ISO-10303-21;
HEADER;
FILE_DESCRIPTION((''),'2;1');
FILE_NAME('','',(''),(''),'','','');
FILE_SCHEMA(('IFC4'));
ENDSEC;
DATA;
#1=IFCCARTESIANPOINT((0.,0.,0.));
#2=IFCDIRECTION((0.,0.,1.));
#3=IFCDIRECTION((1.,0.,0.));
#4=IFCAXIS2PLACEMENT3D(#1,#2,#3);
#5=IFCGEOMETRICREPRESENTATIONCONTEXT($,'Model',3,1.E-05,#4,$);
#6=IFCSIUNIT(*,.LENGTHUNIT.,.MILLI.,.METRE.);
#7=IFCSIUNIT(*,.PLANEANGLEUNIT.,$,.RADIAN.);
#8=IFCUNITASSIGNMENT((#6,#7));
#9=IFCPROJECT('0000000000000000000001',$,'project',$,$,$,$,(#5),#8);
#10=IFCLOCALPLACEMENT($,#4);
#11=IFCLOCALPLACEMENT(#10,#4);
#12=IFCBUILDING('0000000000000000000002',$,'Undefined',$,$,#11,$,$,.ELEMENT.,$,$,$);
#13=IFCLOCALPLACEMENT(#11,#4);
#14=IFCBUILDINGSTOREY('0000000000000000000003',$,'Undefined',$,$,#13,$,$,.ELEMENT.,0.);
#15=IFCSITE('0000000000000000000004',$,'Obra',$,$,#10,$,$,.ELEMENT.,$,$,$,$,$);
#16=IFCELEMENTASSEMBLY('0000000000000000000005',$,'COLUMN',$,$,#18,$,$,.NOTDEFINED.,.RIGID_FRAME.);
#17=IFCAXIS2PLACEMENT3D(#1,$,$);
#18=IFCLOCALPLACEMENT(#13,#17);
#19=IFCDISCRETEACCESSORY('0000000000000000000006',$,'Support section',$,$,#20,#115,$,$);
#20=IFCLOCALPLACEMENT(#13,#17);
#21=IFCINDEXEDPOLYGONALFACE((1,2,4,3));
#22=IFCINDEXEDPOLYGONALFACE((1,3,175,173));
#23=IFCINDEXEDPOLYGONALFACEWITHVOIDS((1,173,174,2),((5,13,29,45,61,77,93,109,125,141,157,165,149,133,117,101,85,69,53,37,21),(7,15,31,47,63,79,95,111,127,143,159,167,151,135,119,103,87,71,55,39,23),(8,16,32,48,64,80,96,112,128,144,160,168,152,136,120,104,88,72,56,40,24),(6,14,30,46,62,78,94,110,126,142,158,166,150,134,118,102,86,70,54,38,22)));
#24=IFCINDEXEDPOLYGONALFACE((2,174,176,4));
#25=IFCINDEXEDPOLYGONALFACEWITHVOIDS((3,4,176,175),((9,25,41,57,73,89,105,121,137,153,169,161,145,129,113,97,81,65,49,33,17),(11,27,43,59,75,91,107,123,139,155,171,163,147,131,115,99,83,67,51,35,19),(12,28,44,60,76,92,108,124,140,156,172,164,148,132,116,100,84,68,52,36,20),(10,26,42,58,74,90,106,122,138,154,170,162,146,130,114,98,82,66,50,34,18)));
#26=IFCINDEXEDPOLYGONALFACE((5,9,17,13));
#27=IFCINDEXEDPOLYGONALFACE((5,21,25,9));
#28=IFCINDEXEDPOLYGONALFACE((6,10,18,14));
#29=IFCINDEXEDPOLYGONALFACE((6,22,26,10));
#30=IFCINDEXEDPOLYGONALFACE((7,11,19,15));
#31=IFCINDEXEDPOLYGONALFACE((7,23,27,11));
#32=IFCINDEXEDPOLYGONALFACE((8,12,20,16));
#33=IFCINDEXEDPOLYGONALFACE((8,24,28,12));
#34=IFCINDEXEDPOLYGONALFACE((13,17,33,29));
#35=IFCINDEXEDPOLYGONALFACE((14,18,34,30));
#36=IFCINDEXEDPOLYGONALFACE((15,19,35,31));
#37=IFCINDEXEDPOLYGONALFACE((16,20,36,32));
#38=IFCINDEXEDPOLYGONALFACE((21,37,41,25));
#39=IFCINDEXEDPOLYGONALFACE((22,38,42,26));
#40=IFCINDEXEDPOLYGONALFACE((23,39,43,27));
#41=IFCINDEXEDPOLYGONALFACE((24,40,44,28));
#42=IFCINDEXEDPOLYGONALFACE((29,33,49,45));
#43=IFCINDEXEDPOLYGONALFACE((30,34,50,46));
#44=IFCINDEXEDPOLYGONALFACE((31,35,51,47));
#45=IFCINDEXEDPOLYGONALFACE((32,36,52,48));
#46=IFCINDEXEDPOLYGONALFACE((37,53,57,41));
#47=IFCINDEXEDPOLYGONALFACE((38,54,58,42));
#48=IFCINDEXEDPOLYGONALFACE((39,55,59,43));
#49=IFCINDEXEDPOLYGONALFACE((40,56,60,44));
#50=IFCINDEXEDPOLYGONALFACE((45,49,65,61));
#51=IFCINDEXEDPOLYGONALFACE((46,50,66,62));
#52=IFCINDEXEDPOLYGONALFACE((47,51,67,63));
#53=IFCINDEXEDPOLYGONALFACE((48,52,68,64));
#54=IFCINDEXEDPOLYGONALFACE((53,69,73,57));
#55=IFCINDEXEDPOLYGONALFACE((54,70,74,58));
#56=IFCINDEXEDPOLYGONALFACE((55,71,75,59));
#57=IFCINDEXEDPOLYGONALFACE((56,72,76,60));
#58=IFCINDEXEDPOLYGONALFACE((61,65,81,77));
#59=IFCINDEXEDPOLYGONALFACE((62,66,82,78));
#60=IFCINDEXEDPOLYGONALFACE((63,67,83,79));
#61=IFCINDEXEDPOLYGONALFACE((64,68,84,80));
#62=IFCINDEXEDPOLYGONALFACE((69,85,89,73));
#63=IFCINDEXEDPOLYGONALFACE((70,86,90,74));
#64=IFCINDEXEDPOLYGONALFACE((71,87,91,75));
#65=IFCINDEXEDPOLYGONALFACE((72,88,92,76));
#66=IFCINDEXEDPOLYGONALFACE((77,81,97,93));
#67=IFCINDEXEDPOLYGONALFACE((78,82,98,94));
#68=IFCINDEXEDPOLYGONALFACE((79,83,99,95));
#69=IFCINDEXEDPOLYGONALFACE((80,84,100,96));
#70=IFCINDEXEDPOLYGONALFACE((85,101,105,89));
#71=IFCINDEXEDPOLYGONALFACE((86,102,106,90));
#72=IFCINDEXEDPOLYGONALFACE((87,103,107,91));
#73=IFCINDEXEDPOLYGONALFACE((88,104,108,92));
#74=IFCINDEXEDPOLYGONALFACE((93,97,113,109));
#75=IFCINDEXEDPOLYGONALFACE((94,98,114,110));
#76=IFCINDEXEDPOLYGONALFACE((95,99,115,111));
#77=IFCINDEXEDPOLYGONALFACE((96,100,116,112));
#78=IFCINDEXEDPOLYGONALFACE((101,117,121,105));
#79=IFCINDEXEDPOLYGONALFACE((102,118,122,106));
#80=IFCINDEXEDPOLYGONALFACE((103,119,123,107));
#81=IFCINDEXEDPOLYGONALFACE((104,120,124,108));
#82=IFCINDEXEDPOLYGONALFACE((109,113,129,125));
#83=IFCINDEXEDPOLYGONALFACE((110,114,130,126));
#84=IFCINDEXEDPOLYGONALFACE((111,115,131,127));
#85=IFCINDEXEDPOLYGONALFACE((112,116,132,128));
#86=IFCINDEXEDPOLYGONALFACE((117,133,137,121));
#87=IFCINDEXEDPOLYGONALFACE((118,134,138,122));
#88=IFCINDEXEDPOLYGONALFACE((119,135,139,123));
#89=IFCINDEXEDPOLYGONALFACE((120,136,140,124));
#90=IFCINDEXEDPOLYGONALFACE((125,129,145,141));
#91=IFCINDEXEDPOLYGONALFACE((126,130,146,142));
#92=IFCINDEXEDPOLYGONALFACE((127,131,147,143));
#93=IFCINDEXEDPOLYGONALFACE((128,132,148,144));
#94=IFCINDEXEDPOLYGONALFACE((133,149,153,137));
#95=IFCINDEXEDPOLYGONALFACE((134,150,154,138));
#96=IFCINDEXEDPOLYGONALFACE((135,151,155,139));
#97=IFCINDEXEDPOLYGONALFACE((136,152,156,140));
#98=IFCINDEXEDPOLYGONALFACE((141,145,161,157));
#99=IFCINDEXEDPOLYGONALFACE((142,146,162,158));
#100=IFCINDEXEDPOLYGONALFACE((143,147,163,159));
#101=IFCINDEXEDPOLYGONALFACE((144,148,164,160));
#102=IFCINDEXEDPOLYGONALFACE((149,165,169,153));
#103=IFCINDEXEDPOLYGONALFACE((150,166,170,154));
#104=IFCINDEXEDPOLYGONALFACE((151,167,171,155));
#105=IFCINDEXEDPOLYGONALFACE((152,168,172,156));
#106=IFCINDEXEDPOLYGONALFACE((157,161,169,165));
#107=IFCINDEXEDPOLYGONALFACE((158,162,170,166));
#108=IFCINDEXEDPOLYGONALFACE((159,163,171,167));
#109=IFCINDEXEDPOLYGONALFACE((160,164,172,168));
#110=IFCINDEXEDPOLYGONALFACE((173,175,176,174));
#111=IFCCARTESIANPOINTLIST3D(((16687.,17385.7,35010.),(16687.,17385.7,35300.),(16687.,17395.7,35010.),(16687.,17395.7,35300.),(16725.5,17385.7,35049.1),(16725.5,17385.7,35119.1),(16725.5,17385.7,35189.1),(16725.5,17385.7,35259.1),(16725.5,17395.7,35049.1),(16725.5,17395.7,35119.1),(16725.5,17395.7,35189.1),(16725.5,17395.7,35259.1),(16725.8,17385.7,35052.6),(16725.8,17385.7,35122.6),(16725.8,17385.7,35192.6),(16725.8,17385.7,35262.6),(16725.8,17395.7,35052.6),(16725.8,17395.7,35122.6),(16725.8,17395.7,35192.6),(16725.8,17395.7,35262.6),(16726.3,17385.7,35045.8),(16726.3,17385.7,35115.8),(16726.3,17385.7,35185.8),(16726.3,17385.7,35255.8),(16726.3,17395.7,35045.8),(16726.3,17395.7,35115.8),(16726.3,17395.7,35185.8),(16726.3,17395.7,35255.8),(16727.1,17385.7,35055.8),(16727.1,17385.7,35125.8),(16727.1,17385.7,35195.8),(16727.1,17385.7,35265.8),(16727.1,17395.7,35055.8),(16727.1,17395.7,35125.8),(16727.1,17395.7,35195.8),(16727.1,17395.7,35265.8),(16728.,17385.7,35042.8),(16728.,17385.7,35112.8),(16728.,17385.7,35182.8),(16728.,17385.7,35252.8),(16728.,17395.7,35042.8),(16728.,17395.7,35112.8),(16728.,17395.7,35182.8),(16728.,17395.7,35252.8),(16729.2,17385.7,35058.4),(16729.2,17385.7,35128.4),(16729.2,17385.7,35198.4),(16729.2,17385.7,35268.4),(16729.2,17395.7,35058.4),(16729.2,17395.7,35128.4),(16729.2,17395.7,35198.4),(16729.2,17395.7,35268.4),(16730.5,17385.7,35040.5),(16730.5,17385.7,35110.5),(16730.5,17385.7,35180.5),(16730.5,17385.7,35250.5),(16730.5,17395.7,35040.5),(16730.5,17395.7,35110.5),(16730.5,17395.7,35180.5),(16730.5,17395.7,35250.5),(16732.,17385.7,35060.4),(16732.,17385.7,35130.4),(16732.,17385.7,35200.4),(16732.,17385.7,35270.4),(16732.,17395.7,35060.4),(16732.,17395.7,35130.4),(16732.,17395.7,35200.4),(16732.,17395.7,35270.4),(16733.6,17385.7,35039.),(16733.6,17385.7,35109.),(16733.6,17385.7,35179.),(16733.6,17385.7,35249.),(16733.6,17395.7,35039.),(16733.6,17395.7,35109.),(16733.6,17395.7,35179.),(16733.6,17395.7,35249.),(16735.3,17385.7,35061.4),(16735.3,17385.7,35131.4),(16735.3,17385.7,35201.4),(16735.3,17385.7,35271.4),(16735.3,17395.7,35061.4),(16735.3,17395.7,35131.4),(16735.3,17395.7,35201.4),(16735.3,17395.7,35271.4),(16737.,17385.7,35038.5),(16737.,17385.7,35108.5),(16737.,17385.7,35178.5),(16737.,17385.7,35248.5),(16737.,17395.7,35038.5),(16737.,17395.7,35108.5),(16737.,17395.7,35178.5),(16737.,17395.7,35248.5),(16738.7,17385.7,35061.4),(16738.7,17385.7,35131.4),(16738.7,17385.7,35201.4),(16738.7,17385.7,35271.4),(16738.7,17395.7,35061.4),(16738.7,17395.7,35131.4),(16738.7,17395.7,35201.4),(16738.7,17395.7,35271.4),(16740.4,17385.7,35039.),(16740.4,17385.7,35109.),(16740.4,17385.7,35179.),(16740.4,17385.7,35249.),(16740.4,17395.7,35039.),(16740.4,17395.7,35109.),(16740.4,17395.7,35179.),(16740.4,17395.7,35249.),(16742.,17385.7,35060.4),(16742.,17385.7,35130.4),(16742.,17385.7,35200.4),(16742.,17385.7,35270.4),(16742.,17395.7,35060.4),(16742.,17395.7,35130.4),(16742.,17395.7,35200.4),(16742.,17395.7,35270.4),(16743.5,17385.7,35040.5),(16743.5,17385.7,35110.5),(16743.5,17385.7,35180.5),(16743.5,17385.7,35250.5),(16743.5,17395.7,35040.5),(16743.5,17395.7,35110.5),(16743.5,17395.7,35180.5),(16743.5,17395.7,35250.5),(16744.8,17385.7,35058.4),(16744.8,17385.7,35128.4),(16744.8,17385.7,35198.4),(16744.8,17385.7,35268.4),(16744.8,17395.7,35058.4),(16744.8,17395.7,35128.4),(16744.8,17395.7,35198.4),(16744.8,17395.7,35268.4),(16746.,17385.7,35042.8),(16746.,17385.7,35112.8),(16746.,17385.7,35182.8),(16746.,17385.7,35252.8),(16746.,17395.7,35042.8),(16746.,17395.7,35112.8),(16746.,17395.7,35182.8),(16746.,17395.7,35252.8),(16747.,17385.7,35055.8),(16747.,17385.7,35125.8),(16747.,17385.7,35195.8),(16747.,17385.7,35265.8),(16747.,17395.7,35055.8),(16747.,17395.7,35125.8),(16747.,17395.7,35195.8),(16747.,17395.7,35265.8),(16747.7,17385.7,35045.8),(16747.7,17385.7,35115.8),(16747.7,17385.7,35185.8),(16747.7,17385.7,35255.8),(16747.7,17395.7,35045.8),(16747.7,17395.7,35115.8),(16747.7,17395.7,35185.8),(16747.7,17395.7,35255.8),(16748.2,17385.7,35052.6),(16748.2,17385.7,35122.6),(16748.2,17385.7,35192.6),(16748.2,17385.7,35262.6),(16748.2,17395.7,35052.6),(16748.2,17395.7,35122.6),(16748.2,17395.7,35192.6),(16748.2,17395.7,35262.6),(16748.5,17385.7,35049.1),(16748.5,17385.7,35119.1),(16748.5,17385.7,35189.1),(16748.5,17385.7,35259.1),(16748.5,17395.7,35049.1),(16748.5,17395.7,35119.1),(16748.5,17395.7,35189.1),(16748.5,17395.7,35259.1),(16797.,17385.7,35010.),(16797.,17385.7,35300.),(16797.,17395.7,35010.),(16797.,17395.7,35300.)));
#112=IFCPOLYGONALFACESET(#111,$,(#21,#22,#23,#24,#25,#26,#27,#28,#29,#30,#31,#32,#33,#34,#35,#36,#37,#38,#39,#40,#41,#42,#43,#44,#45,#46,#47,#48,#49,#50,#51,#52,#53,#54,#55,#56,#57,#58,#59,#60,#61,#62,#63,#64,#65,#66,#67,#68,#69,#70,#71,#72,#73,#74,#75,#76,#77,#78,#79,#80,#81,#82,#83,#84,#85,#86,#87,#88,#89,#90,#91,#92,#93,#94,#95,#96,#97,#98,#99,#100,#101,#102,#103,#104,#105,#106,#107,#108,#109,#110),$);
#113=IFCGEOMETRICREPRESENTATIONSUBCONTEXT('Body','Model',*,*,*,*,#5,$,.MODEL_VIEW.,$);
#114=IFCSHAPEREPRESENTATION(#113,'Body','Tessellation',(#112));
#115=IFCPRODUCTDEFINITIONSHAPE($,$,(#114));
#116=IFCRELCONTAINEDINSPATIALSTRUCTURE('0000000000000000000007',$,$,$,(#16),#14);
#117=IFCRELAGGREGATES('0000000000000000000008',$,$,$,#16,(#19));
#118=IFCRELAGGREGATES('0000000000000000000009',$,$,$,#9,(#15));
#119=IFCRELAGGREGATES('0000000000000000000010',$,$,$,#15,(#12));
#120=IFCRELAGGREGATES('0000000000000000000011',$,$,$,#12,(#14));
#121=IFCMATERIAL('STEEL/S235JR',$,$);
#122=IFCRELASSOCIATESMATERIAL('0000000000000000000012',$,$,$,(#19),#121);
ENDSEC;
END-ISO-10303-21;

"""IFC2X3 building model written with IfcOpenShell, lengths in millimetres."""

from ifc_helpers import new_model, si_unit, frame, origin_with_axes, origin_2d_with_axis, place, context, subcontext, project, spatial, rectangle, circle, extrude, source, transform, mapped, material, element, aggregate, save


model = new_model("IFC2X3")

# Units and contexts
model_context = context("Model", 3, precision=1e-05, world=origin_with_axes())
body_context = subcontext(model_context, "Body", "Model", "MODEL_VIEW")
ifc_project = project(units=[si_unit("LENGTHUNIT", "METRE", prefix="MILLI"), si_unit("PLANEANGLEUNIT", "RADIAN")], contexts=[model_context])

# Site, building, storey
site_placement = place(None, origin_with_axes())
site = spatial("IfcSite", under=ifc_project, at=site_placement, Name="Obra", CompositionType="ELEMENT")
building_placement = place(site_placement, origin_with_axes())
building = spatial("IfcBuilding", under=site, at=building_placement, Name="Undefined", CompositionType="ELEMENT")
storey_placement = place(building_placement, origin_with_axes())
storey = spatial("IfcBuildingStorey", under=building, at=storey_placement, Name="Undefined", CompositionType="ELEMENT", Elevation=0.0)

# Shared definitions
ifc_material_1 = material(Name="STEEL/S235JR")

# Element assembly, discrete accessory, opening
assembly_1_placement = place(storey_placement, origin_with_axes())
assembly_1 = element("IfcElementAssembly", 1, at=assembly_1_placement, inside=storey, Name="COLUMN", AssemblyPlace="NOTDEFINED", PredefinedType="RIGID_FRAME")
discrete_accessory_1_placement = place(assembly_1_placement, frame((16742.0, 17390.7, 35010.0), z_axis=(0.0, 0.0, 1.0), x_axis=(1.0, 0.0, 0.0)))
discrete_accessory_1 = element("IfcDiscreteAccessory", 2, at=discrete_accessory_1_placement, material=ifc_material_1, Name="Support section", context=body_context, shape_type="SweptSolid", body=[
    extrude(rectangle(XDim=10.0, YDim=110.0, at=origin_2d_with_axis()), frame((0.0, 0.0, 290.0), z_axis=(0.0, 0.0, -1.0), x_axis=(0.0, 1.0, 0.0)), (0.0, 0.0, 1.0), 290.0),
])
shared_shape_1 = source(origin_with_axes(), body_context, "Body", "SweptSolid", [
    extrude(circle(Radius=11.5, at=origin_2d_with_axis()), frame((0.0, -15.6, 0.0), z_axis=(0.0, 1.0, 0.0), x_axis=(1.0, 0.0, 0.0)), (0.0, 0.0, 1.0), 10.2),
])
opening_1_placement = place(assembly_1_placement, frame((16787.0, 17380.2, 35350.0), z_axis=(-1.0, 0.0, 0.0), x_axis=(0.0, 0.0, -1.0)))
element("IfcOpeningElement", 3, at=opening_1_placement, cuts=discrete_accessory_1, ObjectType="Opening", context=body_context, shape_type="MappedRepresentation", body=[
    mapped(shared_shape_1, transform((90.0, 0.0, 50.0))),
    mapped(shared_shape_1, transform((160.0, 0.0, 50.0))),
    mapped(shared_shape_1, transform((230.0, 0.0, 50.0))),
    mapped(shared_shape_1, transform((300.0, 0.0, 50.0))),
])

aggregate(assembly_1, [discrete_accessory_1])

save(model, "model.ifc")
